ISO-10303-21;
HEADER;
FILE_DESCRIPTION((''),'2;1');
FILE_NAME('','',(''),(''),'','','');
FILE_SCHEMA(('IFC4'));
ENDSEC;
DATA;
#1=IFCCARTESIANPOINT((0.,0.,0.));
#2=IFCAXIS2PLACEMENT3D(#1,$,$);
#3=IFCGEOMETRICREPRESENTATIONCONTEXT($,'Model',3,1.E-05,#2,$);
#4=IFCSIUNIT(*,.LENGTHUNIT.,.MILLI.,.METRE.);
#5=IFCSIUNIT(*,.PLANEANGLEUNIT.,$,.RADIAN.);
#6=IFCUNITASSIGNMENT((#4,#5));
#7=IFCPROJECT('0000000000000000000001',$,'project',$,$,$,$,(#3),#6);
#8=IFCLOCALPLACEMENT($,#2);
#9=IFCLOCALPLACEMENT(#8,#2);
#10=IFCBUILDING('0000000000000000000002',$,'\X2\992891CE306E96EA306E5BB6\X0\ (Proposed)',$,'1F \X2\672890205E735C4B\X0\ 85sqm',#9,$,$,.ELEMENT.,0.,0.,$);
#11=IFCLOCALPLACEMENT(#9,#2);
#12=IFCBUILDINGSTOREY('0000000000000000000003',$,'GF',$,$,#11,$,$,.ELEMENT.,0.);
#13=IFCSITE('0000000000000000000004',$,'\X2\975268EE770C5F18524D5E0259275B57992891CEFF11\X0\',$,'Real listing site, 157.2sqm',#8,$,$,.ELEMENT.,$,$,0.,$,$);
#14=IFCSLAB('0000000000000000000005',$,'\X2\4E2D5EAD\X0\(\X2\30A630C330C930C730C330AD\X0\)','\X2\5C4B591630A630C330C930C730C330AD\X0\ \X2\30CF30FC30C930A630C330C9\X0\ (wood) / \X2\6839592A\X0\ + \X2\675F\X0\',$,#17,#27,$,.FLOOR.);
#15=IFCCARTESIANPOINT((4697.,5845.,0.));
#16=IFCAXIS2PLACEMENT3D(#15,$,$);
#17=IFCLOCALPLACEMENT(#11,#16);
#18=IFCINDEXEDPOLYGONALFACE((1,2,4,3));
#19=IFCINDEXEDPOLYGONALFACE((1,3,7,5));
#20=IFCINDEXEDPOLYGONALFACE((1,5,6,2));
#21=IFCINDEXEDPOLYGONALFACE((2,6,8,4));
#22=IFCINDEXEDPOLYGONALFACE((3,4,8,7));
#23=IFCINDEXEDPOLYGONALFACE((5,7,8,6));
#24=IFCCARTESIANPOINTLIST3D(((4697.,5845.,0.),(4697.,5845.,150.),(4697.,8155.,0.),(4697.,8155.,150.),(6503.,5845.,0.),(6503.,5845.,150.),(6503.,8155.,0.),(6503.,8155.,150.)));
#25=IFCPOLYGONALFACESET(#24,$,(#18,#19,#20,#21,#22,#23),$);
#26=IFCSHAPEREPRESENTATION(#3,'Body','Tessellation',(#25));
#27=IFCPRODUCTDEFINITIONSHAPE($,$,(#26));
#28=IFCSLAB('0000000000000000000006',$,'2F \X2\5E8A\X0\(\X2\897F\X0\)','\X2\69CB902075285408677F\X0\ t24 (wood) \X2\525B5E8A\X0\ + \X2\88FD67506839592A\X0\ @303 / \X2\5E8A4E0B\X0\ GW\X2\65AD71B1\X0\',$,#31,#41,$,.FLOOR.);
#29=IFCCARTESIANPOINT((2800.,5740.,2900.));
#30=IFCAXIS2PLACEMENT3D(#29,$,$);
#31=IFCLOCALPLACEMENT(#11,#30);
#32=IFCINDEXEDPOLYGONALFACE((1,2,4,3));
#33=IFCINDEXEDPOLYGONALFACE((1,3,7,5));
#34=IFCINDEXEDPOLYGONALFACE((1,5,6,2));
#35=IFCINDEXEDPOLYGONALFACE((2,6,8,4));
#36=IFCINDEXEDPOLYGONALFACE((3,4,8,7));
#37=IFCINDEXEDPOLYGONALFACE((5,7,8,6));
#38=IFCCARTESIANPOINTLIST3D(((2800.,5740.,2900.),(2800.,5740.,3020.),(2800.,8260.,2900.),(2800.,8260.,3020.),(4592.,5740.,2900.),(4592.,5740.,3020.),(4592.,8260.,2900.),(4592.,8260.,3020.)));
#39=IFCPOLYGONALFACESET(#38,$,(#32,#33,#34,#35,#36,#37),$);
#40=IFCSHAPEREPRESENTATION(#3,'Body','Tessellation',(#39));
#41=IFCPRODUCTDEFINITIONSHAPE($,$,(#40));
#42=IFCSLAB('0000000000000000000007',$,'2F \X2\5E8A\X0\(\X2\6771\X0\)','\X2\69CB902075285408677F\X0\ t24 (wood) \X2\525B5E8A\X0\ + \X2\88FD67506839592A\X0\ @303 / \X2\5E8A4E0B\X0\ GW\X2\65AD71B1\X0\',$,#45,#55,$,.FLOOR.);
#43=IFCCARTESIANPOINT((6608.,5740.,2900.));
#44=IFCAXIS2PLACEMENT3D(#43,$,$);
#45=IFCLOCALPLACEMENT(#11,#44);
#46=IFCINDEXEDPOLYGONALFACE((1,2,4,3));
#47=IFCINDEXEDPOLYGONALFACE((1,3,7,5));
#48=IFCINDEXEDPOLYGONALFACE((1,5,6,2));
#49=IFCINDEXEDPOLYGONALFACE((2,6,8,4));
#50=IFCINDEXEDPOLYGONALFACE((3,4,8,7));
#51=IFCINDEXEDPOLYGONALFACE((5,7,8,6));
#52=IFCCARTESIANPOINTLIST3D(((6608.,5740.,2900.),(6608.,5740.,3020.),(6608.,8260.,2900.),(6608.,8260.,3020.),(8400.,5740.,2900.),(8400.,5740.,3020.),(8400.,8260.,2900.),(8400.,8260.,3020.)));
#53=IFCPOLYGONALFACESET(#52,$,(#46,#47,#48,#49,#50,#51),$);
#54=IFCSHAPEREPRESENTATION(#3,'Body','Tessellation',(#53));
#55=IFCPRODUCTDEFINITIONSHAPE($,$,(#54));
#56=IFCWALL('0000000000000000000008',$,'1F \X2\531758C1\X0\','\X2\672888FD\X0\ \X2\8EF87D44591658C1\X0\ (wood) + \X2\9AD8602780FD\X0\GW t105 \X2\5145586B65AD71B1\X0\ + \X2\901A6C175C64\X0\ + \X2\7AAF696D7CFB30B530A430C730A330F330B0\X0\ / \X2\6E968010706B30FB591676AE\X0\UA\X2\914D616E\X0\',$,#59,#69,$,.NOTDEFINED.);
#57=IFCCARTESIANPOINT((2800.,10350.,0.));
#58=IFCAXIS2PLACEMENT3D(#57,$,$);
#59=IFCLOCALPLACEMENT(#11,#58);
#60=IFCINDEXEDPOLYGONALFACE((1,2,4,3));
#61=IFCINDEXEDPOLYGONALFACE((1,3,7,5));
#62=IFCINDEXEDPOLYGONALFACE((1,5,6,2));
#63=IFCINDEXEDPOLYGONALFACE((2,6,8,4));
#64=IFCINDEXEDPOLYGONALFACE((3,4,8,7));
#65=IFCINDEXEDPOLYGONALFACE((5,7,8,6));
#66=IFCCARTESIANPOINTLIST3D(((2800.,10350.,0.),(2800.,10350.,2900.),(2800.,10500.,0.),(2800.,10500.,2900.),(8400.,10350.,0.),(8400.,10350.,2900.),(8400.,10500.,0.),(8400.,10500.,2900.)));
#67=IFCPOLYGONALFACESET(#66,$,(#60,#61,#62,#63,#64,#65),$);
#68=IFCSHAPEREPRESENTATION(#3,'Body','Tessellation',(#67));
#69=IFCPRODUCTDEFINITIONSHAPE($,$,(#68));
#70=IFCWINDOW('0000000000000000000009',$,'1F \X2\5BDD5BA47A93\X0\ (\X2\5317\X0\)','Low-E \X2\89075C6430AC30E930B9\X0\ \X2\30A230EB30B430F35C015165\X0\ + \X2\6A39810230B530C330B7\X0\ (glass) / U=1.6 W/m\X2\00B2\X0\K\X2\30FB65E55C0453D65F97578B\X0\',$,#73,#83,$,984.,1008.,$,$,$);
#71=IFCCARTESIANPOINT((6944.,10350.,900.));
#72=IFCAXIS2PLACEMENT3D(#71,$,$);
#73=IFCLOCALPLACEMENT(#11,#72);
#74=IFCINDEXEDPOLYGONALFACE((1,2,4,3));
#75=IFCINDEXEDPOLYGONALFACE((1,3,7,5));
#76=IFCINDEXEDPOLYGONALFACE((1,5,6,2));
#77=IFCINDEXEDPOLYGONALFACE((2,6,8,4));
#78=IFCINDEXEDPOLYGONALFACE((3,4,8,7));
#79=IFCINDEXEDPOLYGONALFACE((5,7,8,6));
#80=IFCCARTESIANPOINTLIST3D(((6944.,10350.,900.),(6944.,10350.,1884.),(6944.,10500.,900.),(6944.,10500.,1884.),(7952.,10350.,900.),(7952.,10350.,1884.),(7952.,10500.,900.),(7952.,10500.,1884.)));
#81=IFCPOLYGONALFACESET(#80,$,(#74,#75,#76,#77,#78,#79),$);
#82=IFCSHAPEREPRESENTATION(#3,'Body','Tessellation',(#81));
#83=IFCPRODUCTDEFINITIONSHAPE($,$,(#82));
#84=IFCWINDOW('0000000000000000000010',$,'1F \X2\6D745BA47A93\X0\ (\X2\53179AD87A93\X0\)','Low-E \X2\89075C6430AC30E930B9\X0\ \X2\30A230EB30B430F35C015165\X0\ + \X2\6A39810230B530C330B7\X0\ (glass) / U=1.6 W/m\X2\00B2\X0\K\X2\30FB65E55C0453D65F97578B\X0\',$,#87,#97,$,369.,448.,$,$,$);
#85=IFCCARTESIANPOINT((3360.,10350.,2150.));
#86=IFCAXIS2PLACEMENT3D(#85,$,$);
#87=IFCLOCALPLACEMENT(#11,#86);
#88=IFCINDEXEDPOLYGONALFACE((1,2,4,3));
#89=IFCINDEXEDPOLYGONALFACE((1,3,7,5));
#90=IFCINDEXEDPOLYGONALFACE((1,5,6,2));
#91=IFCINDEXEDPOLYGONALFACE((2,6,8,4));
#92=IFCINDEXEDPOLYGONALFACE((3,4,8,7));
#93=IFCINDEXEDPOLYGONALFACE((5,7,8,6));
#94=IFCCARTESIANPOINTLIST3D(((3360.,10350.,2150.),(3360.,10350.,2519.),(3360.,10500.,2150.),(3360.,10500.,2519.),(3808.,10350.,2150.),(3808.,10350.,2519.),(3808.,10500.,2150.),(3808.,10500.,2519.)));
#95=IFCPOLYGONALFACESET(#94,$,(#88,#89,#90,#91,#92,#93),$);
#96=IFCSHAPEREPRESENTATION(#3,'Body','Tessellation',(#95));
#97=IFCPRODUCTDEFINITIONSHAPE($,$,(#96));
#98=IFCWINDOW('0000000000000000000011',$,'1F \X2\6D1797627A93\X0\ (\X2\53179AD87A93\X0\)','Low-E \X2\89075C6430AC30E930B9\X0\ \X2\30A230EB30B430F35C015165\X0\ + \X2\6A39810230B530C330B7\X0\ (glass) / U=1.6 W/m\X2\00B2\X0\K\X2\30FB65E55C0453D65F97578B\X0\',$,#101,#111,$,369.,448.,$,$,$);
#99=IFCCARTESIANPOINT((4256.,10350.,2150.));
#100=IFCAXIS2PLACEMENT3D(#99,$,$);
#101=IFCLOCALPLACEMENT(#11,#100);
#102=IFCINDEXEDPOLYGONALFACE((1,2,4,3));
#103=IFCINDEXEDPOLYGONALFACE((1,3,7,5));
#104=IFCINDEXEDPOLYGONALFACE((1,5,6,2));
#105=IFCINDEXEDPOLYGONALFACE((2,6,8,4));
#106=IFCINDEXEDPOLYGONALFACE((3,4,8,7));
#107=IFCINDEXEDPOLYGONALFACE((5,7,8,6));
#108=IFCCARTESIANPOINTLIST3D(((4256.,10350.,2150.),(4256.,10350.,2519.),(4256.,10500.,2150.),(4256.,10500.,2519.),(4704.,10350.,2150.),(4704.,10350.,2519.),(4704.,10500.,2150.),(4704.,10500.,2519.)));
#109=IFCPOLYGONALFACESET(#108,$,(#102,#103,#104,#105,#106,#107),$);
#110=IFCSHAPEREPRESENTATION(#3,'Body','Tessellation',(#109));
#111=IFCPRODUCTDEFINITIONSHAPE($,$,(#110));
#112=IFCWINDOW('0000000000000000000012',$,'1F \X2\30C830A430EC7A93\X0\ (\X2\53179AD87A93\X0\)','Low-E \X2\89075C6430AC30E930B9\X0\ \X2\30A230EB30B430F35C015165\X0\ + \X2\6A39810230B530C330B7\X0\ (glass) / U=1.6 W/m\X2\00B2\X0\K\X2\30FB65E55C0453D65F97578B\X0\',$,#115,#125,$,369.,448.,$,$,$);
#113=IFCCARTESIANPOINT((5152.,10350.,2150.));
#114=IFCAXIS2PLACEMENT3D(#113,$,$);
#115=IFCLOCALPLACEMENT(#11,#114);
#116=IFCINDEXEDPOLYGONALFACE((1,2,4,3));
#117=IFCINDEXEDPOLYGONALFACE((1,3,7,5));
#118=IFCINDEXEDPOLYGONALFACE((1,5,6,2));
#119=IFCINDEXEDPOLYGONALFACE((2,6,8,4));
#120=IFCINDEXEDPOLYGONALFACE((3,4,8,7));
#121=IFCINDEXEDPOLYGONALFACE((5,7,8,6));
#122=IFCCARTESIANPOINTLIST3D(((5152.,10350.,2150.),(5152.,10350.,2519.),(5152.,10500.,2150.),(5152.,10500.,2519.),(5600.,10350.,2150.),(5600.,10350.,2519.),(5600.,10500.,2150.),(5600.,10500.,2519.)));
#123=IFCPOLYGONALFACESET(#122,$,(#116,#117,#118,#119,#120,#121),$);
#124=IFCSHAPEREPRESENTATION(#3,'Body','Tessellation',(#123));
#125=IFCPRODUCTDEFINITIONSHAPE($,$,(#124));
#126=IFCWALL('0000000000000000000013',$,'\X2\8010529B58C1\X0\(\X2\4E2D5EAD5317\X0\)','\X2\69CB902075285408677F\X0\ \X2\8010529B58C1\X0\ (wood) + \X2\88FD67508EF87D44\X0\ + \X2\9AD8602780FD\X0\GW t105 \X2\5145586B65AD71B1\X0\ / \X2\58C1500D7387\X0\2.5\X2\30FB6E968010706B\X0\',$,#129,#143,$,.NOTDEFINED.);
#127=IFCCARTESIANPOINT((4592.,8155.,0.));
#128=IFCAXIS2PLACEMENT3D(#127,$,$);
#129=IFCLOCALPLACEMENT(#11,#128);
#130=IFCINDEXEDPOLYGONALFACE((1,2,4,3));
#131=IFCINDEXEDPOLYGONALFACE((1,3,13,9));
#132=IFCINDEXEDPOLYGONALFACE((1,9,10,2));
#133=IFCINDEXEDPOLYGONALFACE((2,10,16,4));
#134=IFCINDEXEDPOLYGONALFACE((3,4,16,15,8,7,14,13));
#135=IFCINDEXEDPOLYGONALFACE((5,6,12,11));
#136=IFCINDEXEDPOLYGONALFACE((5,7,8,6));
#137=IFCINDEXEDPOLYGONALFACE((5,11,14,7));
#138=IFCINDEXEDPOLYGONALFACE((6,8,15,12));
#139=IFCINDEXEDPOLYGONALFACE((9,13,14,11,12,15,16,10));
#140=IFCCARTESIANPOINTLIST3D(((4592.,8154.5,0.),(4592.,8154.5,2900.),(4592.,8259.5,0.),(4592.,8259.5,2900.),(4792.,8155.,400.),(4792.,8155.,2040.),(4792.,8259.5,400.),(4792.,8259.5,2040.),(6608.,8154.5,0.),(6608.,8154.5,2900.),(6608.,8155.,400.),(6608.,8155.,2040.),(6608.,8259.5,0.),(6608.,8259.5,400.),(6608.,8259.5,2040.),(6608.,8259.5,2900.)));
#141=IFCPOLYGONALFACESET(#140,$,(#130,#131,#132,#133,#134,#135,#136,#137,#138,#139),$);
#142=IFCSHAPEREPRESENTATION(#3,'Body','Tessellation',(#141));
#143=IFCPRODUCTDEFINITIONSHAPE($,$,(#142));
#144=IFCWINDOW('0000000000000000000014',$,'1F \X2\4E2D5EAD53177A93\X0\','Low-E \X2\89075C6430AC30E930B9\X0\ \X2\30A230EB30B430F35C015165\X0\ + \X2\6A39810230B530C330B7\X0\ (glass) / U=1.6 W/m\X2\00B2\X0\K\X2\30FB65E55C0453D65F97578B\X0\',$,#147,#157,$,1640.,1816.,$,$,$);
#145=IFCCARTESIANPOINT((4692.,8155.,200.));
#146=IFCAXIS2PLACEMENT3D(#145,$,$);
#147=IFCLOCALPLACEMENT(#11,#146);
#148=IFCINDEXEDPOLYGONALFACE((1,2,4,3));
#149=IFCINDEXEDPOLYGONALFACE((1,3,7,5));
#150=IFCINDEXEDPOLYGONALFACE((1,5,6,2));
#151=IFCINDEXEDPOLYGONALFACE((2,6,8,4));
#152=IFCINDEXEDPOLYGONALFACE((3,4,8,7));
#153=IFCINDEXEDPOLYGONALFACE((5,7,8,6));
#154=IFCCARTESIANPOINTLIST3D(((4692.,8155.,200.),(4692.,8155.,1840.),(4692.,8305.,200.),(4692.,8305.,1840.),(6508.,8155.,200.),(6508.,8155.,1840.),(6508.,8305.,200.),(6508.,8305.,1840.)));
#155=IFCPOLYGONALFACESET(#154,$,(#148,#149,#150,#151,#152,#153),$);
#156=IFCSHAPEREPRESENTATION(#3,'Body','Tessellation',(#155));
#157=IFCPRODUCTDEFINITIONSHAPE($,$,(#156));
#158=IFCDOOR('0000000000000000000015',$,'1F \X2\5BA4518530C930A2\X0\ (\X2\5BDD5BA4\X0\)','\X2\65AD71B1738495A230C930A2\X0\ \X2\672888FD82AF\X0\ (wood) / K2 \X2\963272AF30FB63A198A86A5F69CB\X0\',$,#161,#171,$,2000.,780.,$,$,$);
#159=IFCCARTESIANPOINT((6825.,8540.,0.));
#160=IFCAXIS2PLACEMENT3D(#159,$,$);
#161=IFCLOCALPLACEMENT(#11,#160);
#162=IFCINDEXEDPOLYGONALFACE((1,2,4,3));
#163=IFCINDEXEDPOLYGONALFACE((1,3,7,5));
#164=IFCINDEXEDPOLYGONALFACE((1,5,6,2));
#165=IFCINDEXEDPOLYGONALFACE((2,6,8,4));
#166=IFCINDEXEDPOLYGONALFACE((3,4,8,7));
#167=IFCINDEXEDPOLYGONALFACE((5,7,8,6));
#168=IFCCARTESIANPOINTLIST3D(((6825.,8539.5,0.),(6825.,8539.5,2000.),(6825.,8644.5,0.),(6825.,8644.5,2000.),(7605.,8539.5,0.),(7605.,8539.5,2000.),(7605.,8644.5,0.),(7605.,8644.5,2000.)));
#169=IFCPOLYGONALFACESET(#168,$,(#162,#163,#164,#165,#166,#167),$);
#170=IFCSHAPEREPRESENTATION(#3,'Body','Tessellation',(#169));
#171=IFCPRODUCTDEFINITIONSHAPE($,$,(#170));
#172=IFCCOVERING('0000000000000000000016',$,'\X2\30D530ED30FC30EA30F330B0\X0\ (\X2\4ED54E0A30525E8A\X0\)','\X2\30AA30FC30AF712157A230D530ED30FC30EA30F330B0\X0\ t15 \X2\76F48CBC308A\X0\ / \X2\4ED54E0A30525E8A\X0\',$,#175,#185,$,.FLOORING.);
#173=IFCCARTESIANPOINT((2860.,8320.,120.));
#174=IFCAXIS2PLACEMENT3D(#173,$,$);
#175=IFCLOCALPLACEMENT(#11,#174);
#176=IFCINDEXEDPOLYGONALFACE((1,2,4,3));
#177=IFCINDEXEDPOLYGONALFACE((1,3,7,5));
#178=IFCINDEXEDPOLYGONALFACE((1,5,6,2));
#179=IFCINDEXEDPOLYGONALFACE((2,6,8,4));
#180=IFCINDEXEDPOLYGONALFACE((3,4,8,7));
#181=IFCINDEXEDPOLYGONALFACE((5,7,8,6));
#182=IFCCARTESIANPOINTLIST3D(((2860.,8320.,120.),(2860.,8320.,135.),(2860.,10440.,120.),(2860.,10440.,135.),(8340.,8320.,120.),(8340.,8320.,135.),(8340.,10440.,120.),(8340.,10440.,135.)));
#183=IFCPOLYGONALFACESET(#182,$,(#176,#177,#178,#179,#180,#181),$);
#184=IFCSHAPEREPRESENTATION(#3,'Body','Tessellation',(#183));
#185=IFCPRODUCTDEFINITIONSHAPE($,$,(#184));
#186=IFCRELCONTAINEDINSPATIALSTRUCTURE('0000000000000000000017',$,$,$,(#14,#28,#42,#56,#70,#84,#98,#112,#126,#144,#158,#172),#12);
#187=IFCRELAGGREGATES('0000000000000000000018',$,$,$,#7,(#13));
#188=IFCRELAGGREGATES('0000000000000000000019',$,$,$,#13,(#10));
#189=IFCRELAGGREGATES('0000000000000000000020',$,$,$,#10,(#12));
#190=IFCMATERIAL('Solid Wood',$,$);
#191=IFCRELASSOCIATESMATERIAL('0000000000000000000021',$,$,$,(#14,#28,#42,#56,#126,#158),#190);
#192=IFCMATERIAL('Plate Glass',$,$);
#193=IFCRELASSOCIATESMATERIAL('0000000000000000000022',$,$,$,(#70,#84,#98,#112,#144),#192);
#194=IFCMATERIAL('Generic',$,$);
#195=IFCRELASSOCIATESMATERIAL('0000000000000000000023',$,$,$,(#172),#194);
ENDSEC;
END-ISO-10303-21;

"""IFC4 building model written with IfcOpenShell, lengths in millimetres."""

from ifc_helpers import new_model, si_unit, frame, frame_2d, origin, place, context, project, spatial, rectangle, extrude, material, element, fill, save


model = new_model("IFC4")

# Units and contexts
model_context = context("Model", 3, precision=1e-05, world=origin())
ifc_project = project(units=[si_unit("LENGTHUNIT", "METRE", prefix="MILLI"), si_unit("PLANEANGLEUNIT", "RADIAN")], contexts=[model_context])

# Site, building, storey
site_placement = place(None, origin())
site = spatial("IfcSite", under=ifc_project, at=site_placement, Name="青森県弘前市大字館野１", ObjectType="Real listing site, 157.2sqm", CompositionType="ELEMENT", RefElevation=0.0)
building_placement = place(site_placement, origin())
building = spatial("IfcBuilding", under=site, at=building_placement, Name="館野の雪の家 (Proposed)", ObjectType="1F 木造平屋 85sqm", CompositionType="ELEMENT", ElevationOfRefHeight=0.0, ElevationOfTerrain=0.0)
storey_placement = place(building_placement, origin())
storey = spatial("IfcBuildingStorey", under=building, at=storey_placement, Name="GF", CompositionType="ELEMENT", Elevation=0.0)

# Slabs
ifc_material_1 = material(Name="Solid Wood")
slab_1_placement = place(storey_placement, frame((4697.0, 5845.0, 0.0)))
element("IfcSlab", 1, at=slab_1_placement, inside=storey, material=ifc_material_1, Name="中庭(ウッドデッキ)", Description="屋外ウッドデッキ ハードウッド (wood) / 根太 + 束", PredefinedType="FLOOR", context=model_context, shape_type="SweptSolid", body=[
    extrude(rectangle(XDim=1806.0, YDim=2310.0, at=frame_2d((903.0, 1155.0))), frame((4697.0, 5845.0, 0.0)), (0.0, 0.0, 1.0), 150.0),
])
slab_2_placement = place(storey_placement, frame((2800.0, 5740.0, 2900.0)))
element("IfcSlab", 2, at=slab_2_placement, inside=storey, material=ifc_material_1, Name="2F 床(西)", Description="構造用合板 t24 (wood) 剛床 + 製材根太 @303 / 床下 GW断熱", PredefinedType="FLOOR", context=model_context, shape_type="SweptSolid", body=[
    extrude(rectangle(XDim=1792.0, YDim=2520.0, at=frame_2d((896.0, 1260.0))), frame((2800.0, 5740.0, 2900.0)), (0.0, 0.0, 1.0), 120.0),
])
slab_3_placement = place(storey_placement, frame((6608.0, 5740.0, 2900.0)))
element("IfcSlab", 3, at=slab_3_placement, inside=storey, material=ifc_material_1, Name="2F 床(東)", Description="構造用合板 t24 (wood) 剛床 + 製材根太 @303 / 床下 GW断熱", PredefinedType="FLOOR", context=model_context, shape_type="SweptSolid", body=[
    extrude(rectangle(XDim=1792.0, YDim=2520.0, at=frame_2d((896.0, 1260.0))), frame((6608.0, 5740.0, 2900.0)), (0.0, 0.0, 1.0), 120.0),
])

# Wall, openings, windows
wall_1_placement = place(storey_placement, frame((2800.0, 10350.0, 0.0)))
wall_1 = element("IfcWall", 4, at=wall_1_placement, inside=storey, material=ifc_material_1, Name="1F 北壁", Description="木製 軸組外壁 (wood) + 高性能GW t105 充填断熱 + 通気層 + 窯業系サイディング / 準耐火・外皮UA配慮", PredefinedType="NOTDEFINED", context=model_context, shape_type="SweptSolid", body=[
    extrude(rectangle(XDim=5600.0, YDim=150.0, at=frame_2d((2800.0, 75.0))), frame((2800.0, 10350.0, 0.0)), (0.0, 0.0, 1.0), 2900.0),
])
opening_1_placement = place(storey_placement, frame((6944.0, 10350.0, 900.0)))
opening_1 = element("IfcOpeningElement", 5, at=opening_1_placement, cuts=wall_1, PredefinedType="NOTDEFINED", context=model_context, shape_type="SweptSolid", body=[
    extrude(rectangle(XDim=1008.0, YDim=150.0, at=frame_2d((504.0, 75.0))), frame((6944.0, 10350.0, 900.0)), (0.0, 0.0, 1.0), 984.0),
])
opening_2_placement = place(storey_placement, frame((3360.0, 10350.0, 2150.0)))
opening_2 = element("IfcOpeningElement", 6, at=opening_2_placement, cuts=wall_1, PredefinedType="NOTDEFINED", context=model_context, shape_type="SweptSolid", body=[
    extrude(rectangle(XDim=448.0, YDim=150.0, at=frame_2d((224.0, 75.0))), frame((3360.0, 10350.0, 2150.0)), (0.0, 0.0, 1.0), 369.0),
])
opening_3_placement = place(storey_placement, frame((4256.0, 10350.0, 2150.0)))
opening_3 = element("IfcOpeningElement", 7, at=opening_3_placement, cuts=wall_1, PredefinedType="NOTDEFINED", context=model_context, shape_type="SweptSolid", body=[
    extrude(rectangle(XDim=448.0, YDim=150.0, at=frame_2d((224.0, 75.0))), frame((4256.0, 10350.0, 2150.0)), (0.0, 0.0, 1.0), 369.0),
])
opening_4_placement = place(storey_placement, frame((5152.0, 10350.0, 2150.0)))
opening_4 = element("IfcOpeningElement", 8, at=opening_4_placement, cuts=wall_1, PredefinedType="NOTDEFINED", context=model_context, shape_type="SweptSolid", body=[
    extrude(rectangle(XDim=448.0, YDim=150.0, at=frame_2d((224.0, 75.0))), frame((5152.0, 10350.0, 2150.0)), (0.0, 0.0, 1.0), 369.0),
])
ifc_material_2 = material(Name="Plate Glass")
window_1_placement = place(storey_placement, frame((6944.0, 10350.0, 900.0)))
window_1 = element("IfcWindow", 9, at=window_1_placement, inside=storey, material=ifc_material_2, Name="1F 寝室窓 (北)", Description="Low-E 複層ガラス アルゴン封入 + 樹脂サッシ (glass) / U=1.6 W/m²K・日射取得型", OverallHeight=984.0, OverallWidth=1008.0, context=model_context, shape_type="SweptSolid", body=[
    extrude(rectangle(XDim=1008.0, YDim=150.0, at=frame_2d((504.0, 75.0))), frame((6944.0, 10350.0, 900.0)), (0.0, 0.0, 1.0), 984.0),
])
fill(opening_1, window_1)
window_2_placement = place(storey_placement, frame((3360.0, 10350.0, 2150.0)))
window_2 = element("IfcWindow", 10, at=window_2_placement, inside=storey, material=ifc_material_2, Name="1F 浴室窓 (北高窓)", Description="Low-E 複層ガラス アルゴン封入 + 樹脂サッシ (glass) / U=1.6 W/m²K・日射取得型", OverallHeight=369.0, OverallWidth=448.0, context=model_context, shape_type="SweptSolid", body=[
    extrude(rectangle(XDim=448.0, YDim=150.0, at=frame_2d((224.0, 75.0))), frame((3360.0, 10350.0, 2150.0)), (0.0, 0.0, 1.0), 369.0),
])
fill(opening_2, window_2)
window_3_placement = place(storey_placement, frame((4256.0, 10350.0, 2150.0)))
window_3 = element("IfcWindow", 11, at=window_3_placement, inside=storey, material=ifc_material_2, Name="1F 洗面窓 (北高窓)", Description="Low-E 複層ガラス アルゴン封入 + 樹脂サッシ (glass) / U=1.6 W/m²K・日射取得型", OverallHeight=369.0, OverallWidth=448.0, context=model_context, shape_type="SweptSolid", body=[
    extrude(rectangle(XDim=448.0, YDim=150.0, at=frame_2d((224.0, 75.0))), frame((4256.0, 10350.0, 2150.0)), (0.0, 0.0, 1.0), 369.0),
])
fill(opening_3, window_3)
window_4_placement = place(storey_placement, frame((5152.0, 10350.0, 2150.0)))
window_4 = element("IfcWindow", 12, at=window_4_placement, inside=storey, material=ifc_material_2, Name="1F トイレ窓 (北高窓)", Description="Low-E 複層ガラス アルゴン封入 + 樹脂サッシ (glass) / U=1.6 W/m²K・日射取得型", OverallHeight=369.0, OverallWidth=448.0, context=model_context, shape_type="SweptSolid", body=[
    extrude(rectangle(XDim=448.0, YDim=150.0, at=frame_2d((224.0, 75.0))), frame((5152.0, 10350.0, 2150.0)), (0.0, 0.0, 1.0), 369.0),
])
fill(opening_4, window_4)

# Wall, opening, window
wall_2_placement = place(storey_placement, frame((4592.0, 8155.0, 0.0)))
wall_2 = element("IfcWall", 13, at=wall_2_placement, inside=storey, material=ifc_material_1, Name="耐力壁(中庭北)", Description="構造用合板 耐力壁 (wood) + 製材軸組 + 高性能GW t105 充填断熱 / 壁倍率2.5・準耐火", PredefinedType="NOTDEFINED", context=model_context, shape_type="SweptSolid", body=[
    extrude(rectangle(XDim=2016.0, YDim=105.0, at=frame_2d((1008.0, 52.0))), frame((4592.0, 8155.0, 0.0)), (0.0, 0.0, 1.0), 2900.0),
])
opening_5_placement = place(storey_placement, frame((4692.0, 8155.0, 200.0)))
opening_5 = element("IfcOpeningElement", 14, at=opening_5_placement, cuts=wall_2, PredefinedType="NOTDEFINED", context=model_context, shape_type="SweptSolid", body=[
    extrude(rectangle(XDim=1816.0, YDim=150.0, at=frame_2d((908.0, 75.0))), frame((4692.0, 8155.0, 200.0)), (0.0, 0.0, 1.0), 1640.0),
])
window_5_placement = place(storey_placement, frame((4692.0, 8155.0, 200.0)))
window_5 = element("IfcWindow", 15, at=window_5_placement, inside=storey, material=ifc_material_2, Name="1F 中庭北窓", Description="Low-E 複層ガラス アルゴン封入 + 樹脂サッシ (glass) / U=1.6 W/m²K・日射取得型", OverallHeight=1640.0, OverallWidth=1816.0, context=model_context, shape_type="SweptSolid", body=[
    extrude(rectangle(XDim=1816.0, YDim=150.0, at=frame_2d((908.0, 75.0))), frame((4692.0, 8155.0, 200.0)), (0.0, 0.0, 1.0), 1640.0),
])
fill(opening_5, window_5)

# Door
door_1_placement = place(storey_placement, frame((6825.0, 8540.0, 0.0)))
element("IfcDoor", 16, at=door_1_placement, inside=storey, material=ifc_material_1, Name="1F 室内ドア (寝室)", Description="断熱玄関ドア 木製芯 (wood) / K2 防犯・採風機構", OverallHeight=2000.0, OverallWidth=780.0, context=model_context, shape_type="SweptSolid", body=[
    extrude(rectangle(XDim=780.0, YDim=105.0, at=frame_2d((390.0, 52.0))), frame((6825.0, 8540.0, 0.0)), (0.0, 0.0, 1.0), 2000.0),
])

# Covering
ifc_material_3 = material(Name="Generic")
covering_1_placement = place(storey_placement, frame((2860.0, 8320.0, 120.0)))
element("IfcCovering", 17, at=covering_1_placement, inside=storey, material=ifc_material_3, Name="フローリング (仕上げ床)", Description="オーク無垢フローリング t15 直貼り / 仕上げ床", PredefinedType="FLOORING", context=model_context, shape_type="SweptSolid", body=[
    extrude(rectangle(XDim=5480.0, YDim=2120.0, at=frame_2d((2740.0, 1060.0))), frame((2860.0, 8320.0, 120.0)), (0.0, 0.0, 1.0), 15.0),
])

save(model, "model.ifc")
